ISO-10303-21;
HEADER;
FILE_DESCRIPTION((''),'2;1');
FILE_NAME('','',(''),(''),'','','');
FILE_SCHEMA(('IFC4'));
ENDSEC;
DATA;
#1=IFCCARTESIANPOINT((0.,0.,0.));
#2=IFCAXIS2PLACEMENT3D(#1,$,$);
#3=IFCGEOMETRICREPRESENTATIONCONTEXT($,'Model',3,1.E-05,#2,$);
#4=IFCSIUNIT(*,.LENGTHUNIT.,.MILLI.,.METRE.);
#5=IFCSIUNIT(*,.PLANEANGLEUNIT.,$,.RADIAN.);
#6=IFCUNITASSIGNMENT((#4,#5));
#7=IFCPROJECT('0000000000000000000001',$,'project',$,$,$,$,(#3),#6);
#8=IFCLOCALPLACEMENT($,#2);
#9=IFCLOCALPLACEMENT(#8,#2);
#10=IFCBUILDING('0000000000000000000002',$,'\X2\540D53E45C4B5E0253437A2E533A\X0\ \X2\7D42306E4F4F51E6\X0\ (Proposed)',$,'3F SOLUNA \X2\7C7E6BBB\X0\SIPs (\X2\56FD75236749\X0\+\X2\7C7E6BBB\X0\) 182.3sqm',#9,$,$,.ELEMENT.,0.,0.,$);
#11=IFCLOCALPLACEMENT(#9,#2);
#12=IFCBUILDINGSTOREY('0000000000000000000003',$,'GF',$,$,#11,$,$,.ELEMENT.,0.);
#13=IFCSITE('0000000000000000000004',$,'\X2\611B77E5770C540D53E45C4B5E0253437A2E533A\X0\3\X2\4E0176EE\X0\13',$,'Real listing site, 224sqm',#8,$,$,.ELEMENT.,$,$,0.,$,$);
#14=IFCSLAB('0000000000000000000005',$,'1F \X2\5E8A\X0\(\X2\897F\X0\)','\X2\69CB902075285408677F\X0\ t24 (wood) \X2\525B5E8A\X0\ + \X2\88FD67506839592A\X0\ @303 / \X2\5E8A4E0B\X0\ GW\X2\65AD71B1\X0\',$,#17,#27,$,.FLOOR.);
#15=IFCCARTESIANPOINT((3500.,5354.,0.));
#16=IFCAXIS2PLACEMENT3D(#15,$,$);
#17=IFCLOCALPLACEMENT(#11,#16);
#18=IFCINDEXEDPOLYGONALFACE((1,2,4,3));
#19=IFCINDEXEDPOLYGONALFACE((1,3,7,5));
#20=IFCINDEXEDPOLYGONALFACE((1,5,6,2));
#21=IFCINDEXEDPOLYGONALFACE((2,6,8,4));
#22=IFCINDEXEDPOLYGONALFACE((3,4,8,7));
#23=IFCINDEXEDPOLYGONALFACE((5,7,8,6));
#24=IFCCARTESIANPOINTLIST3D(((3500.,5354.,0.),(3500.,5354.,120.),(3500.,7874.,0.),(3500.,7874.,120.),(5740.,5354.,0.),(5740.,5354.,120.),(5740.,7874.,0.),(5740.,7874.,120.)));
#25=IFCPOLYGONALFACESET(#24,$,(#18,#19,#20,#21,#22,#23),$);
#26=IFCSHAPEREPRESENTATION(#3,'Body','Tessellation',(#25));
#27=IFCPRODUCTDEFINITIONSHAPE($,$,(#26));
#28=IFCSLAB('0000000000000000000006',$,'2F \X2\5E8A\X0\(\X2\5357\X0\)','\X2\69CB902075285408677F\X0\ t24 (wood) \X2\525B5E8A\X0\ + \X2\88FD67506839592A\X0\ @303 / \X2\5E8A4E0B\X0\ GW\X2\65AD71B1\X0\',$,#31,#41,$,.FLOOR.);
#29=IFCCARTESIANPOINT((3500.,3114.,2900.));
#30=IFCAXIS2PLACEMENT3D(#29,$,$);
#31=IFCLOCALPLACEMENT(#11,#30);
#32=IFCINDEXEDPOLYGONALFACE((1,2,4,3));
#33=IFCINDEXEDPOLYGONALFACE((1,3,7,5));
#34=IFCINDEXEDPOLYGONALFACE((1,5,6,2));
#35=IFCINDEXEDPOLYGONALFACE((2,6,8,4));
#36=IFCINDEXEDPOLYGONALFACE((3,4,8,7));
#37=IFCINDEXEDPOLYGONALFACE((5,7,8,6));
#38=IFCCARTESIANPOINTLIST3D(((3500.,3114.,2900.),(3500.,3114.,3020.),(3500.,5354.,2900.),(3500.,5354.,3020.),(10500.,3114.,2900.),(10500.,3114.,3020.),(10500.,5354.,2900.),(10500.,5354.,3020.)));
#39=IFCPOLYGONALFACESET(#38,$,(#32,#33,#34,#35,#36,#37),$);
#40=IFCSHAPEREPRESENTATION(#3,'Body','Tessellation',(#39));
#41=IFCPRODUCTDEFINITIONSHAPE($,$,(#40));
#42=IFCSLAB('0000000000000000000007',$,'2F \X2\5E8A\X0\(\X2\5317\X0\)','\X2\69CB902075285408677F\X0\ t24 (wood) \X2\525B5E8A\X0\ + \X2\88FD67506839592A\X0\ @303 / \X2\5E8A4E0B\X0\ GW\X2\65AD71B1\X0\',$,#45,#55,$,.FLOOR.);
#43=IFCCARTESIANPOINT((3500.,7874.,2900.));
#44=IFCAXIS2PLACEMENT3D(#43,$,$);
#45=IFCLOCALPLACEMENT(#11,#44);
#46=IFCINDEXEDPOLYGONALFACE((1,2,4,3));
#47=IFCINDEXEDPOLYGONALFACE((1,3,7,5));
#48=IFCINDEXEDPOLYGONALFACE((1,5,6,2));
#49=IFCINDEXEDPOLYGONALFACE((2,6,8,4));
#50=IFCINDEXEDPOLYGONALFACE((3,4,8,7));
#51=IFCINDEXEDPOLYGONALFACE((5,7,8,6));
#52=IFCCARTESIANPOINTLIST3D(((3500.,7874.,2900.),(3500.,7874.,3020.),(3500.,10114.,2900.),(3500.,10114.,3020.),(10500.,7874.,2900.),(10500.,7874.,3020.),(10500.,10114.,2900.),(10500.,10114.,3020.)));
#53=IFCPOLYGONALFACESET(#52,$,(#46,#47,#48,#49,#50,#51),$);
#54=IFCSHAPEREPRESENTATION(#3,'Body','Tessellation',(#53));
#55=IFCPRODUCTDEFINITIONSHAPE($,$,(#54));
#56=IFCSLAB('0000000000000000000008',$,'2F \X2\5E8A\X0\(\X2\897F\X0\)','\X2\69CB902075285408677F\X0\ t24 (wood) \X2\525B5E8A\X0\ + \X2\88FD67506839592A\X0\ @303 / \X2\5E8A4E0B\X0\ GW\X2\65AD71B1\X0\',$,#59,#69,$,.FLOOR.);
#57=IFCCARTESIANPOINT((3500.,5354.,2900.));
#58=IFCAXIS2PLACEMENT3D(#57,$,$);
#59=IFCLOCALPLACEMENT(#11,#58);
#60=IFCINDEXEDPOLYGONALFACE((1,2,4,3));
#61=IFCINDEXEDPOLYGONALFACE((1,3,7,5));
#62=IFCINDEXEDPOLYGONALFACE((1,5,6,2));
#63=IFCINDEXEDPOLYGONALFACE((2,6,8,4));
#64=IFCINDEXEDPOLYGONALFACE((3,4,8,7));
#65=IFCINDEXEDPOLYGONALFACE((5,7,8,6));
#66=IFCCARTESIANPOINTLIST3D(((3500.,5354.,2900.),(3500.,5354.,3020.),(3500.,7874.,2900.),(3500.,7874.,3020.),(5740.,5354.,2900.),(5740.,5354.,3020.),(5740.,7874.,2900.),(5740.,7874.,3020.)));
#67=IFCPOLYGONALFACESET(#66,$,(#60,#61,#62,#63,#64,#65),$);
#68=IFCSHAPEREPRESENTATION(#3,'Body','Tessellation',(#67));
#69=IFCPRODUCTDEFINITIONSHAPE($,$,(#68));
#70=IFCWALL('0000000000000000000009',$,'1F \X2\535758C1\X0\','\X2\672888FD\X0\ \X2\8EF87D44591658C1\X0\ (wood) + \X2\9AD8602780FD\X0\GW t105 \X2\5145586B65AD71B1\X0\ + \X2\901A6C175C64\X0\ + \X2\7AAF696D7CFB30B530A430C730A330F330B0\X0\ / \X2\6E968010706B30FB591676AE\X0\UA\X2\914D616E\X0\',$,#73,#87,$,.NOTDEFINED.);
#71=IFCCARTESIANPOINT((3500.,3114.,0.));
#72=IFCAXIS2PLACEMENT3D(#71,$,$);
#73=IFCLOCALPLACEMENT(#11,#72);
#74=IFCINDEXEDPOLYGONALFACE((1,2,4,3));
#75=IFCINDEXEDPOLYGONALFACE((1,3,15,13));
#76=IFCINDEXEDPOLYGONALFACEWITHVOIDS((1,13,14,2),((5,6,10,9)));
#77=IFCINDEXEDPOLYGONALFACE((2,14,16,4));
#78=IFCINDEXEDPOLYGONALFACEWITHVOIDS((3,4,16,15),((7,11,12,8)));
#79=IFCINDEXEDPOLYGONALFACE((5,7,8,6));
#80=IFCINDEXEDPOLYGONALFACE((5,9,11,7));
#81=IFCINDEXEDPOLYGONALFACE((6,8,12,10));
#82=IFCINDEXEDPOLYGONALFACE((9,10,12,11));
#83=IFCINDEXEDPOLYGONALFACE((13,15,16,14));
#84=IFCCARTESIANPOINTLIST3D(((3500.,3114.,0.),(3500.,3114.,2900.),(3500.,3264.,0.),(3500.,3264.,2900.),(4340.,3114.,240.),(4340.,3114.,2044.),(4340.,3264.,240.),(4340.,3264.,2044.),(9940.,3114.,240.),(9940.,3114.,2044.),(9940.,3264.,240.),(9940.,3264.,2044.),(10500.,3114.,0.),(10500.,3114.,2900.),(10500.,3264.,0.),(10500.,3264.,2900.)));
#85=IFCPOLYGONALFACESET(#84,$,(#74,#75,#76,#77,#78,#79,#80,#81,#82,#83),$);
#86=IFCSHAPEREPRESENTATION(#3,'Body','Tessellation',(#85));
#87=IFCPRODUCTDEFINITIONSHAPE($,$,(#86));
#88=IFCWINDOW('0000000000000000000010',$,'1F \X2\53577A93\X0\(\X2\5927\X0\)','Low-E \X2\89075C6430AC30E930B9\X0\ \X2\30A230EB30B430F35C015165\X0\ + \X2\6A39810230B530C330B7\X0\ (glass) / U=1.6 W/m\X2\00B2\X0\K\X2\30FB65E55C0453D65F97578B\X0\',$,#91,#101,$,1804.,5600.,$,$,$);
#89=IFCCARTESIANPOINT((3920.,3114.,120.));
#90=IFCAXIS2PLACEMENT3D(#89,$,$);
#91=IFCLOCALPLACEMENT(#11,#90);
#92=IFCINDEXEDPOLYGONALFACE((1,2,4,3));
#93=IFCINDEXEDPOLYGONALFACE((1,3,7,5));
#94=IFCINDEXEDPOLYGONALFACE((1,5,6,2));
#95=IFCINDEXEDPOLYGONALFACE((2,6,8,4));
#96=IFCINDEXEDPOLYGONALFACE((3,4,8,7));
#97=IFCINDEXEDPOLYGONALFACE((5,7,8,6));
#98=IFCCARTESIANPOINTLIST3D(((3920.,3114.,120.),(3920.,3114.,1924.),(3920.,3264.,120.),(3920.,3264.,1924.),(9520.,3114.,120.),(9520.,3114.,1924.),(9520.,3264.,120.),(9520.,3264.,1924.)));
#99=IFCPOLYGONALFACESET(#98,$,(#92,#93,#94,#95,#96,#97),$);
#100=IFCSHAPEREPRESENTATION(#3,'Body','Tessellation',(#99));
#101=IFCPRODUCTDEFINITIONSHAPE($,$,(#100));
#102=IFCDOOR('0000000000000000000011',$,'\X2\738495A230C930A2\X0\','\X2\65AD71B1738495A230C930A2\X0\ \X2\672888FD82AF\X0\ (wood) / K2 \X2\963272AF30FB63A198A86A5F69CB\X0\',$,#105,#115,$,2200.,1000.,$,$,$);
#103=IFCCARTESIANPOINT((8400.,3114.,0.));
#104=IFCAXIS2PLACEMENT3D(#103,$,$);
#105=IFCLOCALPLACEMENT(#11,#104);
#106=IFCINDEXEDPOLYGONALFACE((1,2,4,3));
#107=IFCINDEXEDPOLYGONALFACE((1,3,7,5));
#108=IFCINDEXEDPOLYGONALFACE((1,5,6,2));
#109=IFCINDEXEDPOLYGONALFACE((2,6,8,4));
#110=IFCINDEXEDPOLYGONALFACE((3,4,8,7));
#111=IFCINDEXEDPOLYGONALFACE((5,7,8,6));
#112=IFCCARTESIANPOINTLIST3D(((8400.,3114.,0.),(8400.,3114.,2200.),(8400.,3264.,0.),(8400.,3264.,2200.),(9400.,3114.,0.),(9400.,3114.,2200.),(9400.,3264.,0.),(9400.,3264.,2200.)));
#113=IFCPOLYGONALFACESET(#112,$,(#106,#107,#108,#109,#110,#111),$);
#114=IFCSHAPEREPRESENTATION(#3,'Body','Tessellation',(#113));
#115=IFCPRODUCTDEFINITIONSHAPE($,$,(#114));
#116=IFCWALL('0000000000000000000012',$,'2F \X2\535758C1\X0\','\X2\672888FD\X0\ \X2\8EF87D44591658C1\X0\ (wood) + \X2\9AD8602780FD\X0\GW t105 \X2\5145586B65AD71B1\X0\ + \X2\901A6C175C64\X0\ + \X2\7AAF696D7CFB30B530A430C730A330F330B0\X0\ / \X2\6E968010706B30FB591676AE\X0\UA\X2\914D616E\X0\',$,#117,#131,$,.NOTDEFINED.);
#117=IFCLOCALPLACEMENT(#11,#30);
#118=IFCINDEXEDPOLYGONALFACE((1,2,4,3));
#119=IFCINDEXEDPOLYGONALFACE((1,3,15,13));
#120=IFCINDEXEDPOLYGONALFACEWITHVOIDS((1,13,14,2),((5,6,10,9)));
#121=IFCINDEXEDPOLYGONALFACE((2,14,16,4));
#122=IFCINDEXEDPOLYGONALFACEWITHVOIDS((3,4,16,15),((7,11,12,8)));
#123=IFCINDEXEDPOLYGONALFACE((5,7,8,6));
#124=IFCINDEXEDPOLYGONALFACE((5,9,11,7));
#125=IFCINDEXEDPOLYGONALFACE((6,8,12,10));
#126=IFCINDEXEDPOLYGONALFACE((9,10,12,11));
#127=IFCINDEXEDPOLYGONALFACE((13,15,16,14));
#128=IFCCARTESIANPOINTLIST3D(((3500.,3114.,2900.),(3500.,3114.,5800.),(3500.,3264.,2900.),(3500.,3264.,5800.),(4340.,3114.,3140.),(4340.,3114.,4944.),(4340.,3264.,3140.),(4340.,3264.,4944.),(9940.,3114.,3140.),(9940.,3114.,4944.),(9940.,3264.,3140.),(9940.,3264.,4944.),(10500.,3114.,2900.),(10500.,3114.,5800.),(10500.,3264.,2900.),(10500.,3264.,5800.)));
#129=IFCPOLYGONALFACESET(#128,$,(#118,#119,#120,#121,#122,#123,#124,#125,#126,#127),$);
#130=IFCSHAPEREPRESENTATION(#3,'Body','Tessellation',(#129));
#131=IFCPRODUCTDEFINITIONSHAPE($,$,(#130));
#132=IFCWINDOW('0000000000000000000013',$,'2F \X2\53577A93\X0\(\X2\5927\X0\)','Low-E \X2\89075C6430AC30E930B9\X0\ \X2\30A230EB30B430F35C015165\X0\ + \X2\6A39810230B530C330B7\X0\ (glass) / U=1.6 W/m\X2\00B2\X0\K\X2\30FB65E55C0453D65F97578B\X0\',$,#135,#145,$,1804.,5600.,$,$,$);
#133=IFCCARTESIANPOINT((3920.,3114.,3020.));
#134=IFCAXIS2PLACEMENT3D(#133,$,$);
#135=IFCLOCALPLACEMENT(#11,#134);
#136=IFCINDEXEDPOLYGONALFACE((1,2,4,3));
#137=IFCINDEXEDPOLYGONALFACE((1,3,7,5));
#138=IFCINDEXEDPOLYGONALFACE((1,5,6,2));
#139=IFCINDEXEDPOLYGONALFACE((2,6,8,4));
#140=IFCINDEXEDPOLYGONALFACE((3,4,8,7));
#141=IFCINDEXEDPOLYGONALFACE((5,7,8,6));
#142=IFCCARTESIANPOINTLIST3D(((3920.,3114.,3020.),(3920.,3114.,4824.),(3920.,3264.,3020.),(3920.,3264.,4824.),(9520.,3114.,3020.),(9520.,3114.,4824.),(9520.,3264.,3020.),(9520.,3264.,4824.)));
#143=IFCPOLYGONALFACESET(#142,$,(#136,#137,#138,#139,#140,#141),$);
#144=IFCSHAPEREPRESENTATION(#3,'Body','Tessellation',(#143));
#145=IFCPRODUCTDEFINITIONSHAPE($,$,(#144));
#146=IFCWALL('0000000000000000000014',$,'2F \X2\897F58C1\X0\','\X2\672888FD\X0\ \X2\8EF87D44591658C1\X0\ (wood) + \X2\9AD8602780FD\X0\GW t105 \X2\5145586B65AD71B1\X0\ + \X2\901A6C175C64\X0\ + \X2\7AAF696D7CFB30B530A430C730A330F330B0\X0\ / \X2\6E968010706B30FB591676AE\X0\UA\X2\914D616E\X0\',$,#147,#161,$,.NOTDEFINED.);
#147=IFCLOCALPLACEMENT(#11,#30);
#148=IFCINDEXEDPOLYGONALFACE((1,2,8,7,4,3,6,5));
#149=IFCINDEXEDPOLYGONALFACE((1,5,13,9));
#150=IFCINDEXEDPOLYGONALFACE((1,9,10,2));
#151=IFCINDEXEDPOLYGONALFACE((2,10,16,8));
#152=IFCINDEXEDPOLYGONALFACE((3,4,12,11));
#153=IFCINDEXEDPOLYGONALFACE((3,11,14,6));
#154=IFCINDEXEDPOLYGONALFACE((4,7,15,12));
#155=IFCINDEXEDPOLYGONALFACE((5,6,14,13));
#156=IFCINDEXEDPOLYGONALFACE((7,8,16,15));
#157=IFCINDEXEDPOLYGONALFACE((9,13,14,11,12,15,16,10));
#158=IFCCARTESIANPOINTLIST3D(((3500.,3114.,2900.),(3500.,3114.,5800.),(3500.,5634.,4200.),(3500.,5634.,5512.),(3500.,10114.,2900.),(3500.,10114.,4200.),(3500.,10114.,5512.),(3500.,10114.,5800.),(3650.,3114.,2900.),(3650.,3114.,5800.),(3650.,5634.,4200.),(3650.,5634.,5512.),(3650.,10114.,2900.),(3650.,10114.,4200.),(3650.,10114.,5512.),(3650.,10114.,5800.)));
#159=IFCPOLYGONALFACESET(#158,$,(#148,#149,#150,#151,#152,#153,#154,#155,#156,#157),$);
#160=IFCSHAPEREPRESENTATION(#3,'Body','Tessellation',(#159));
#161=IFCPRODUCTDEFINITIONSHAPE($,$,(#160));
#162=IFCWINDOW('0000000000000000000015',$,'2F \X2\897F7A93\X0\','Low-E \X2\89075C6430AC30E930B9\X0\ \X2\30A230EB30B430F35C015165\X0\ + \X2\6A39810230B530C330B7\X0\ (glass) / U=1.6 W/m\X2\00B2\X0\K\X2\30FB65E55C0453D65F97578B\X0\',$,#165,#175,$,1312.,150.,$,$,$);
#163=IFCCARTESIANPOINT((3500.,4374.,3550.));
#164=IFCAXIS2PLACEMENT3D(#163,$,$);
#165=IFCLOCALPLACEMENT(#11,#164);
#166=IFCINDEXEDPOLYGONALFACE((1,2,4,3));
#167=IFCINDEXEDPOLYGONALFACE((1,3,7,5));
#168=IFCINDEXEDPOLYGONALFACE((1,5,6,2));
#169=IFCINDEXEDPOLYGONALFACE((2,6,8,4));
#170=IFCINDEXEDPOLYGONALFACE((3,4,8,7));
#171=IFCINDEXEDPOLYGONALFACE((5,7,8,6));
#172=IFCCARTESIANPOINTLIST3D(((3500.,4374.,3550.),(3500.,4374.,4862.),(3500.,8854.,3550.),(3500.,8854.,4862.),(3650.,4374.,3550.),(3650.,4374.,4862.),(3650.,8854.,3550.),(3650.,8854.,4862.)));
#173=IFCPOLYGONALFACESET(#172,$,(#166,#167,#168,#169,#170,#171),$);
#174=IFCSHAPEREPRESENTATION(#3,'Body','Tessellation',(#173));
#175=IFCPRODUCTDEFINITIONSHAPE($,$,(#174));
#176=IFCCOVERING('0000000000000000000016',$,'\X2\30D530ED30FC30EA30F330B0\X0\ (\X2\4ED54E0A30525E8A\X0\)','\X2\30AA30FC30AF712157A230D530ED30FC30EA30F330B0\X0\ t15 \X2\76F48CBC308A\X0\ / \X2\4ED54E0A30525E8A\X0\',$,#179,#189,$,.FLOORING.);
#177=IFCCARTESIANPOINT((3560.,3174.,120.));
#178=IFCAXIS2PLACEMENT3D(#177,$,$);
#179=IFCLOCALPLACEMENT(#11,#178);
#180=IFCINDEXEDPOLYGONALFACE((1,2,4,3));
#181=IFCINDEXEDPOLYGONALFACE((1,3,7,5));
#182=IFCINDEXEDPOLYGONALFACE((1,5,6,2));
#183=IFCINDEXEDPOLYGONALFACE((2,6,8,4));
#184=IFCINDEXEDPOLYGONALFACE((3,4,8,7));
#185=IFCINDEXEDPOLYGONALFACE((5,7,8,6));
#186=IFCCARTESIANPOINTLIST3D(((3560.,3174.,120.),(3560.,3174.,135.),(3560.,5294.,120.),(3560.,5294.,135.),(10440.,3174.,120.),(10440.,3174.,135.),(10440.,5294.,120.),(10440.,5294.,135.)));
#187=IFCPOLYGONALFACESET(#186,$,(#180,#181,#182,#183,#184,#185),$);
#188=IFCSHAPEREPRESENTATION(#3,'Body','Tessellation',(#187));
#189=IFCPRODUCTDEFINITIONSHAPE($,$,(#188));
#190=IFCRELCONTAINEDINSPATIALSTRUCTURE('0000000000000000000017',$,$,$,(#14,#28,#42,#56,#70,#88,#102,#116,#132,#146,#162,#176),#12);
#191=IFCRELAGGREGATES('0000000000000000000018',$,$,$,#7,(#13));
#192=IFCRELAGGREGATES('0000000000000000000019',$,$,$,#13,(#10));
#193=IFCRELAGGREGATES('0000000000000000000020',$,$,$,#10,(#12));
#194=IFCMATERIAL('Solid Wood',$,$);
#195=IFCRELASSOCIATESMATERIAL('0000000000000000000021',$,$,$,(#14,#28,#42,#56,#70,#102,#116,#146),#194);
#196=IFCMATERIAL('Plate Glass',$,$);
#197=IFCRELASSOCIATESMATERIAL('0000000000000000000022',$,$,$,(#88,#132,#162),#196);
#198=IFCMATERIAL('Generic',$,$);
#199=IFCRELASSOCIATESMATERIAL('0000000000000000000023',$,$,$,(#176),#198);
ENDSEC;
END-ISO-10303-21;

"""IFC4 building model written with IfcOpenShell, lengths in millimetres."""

from ifc_helpers import new_model, si_unit, frame, frame_2d, origin, place, context, project, spatial, rectangle, extrude, material, element, fill, save


model = new_model("IFC4")

# Units and contexts
model_context = context("Model", 3, precision=1e-05, world=origin())
ifc_project = project(units=[si_unit("LENGTHUNIT", "METRE", prefix="MILLI"), si_unit("PLANEANGLEUNIT", "RADIAN")], contexts=[model_context])

# Site, building, storey
site_placement = place(None, origin())
site = spatial("IfcSite", under=ifc_project, at=site_placement, Name="愛知県名古屋市千種区3丁目13", ObjectType="Real listing site, 224sqm", CompositionType="ELEMENT", RefElevation=0.0)
building_placement = place(site_placement, origin())
building = spatial("IfcBuilding", under=site, at=building_placement, Name="名古屋市千種区 終の住処 (Proposed)", ObjectType="3F SOLUNA 籾殻SIPs (国産杉+籾殻) 182.3sqm", CompositionType="ELEMENT", ElevationOfRefHeight=0.0, ElevationOfTerrain=0.0)
storey_placement = place(building_placement, origin())
storey = spatial("IfcBuildingStorey", under=building, at=storey_placement, Name="GF", CompositionType="ELEMENT", Elevation=0.0)

# Slabs
ifc_material_1 = material(Name="Solid Wood")
slab_1_placement = place(storey_placement, frame((3500.0, 5354.0, 0.0)))
element("IfcSlab", 1, at=slab_1_placement, inside=storey, material=ifc_material_1, Name="1F 床(西)", Description="構造用合板 t24 (wood) 剛床 + 製材根太 @303 / 床下 GW断熱", PredefinedType="FLOOR", context=model_context, shape_type="SweptSolid", body=[
    extrude(rectangle(XDim=2240.0, YDim=2520.0, at=frame_2d((1120.0, 1260.0))), frame((3500.0, 5354.0, 0.0)), (0.0, 0.0, 1.0), 120.0),
])
slab_2_placement = place(storey_placement, frame((3500.0, 3114.0, 2900.0)))
element("IfcSlab", 2, at=slab_2_placement, inside=storey, material=ifc_material_1, Name="2F 床(南)", Description="構造用合板 t24 (wood) 剛床 + 製材根太 @303 / 床下 GW断熱", PredefinedType="FLOOR", context=model_context, shape_type="SweptSolid", body=[
    extrude(rectangle(XDim=7000.0, YDim=2240.0, at=frame_2d((3500.0, 1120.0))), frame((3500.0, 3114.0, 2900.0)), (0.0, 0.0, 1.0), 120.0),
])
slab_3_placement = place(storey_placement, frame((3500.0, 7874.0, 2900.0)))
element("IfcSlab", 3, at=slab_3_placement, inside=storey, material=ifc_material_1, Name="2F 床(北)", Description="構造用合板 t24 (wood) 剛床 + 製材根太 @303 / 床下 GW断熱", PredefinedType="FLOOR", context=model_context, shape_type="SweptSolid", body=[
    extrude(rectangle(XDim=7000.0, YDim=2240.0, at=frame_2d((3500.0, 1120.0))), frame((3500.0, 7874.0, 2900.0)), (0.0, 0.0, 1.0), 120.0),
])
slab_4_placement = place(storey_placement, frame((3500.0, 5354.0, 2900.0)))
element("IfcSlab", 4, at=slab_4_placement, inside=storey, material=ifc_material_1, Name="2F 床(西)", Description="構造用合板 t24 (wood) 剛床 + 製材根太 @303 / 床下 GW断熱", PredefinedType="FLOOR", context=model_context, shape_type="SweptSolid", body=[
    extrude(rectangle(XDim=2240.0, YDim=2520.0, at=frame_2d((1120.0, 1260.0))), frame((3500.0, 5354.0, 2900.0)), (0.0, 0.0, 1.0), 120.0),
])

# Wall, openings, window, door
wall_1_placement = place(storey_placement, frame((3500.0, 3114.0, 0.0)))
wall_1 = element("IfcWall", 5, at=wall_1_placement, inside=storey, material=ifc_material_1, Name="1F 南壁", Description="木製 軸組外壁 (wood) + 高性能GW t105 充填断熱 + 通気層 + 窯業系サイディング / 準耐火・外皮UA配慮", PredefinedType="NOTDEFINED", context=model_context, shape_type="SweptSolid", body=[
    extrude(rectangle(XDim=7000.0, YDim=150.0, at=frame_2d((3500.0, 75.0))), frame((3500.0, 3114.0, 0.0)), (0.0, 0.0, 1.0), 2900.0),
])
opening_1_placement = place(storey_placement, frame((3920.0, 3114.0, 120.0)))
opening_1 = element("IfcOpeningElement", 6, at=opening_1_placement, cuts=wall_1, PredefinedType="NOTDEFINED", context=model_context, shape_type="SweptSolid", body=[
    extrude(rectangle(XDim=5600.0, YDim=150.0, at=frame_2d((2800.0, 75.0))), frame((3920.0, 3114.0, 120.0)), (0.0, 0.0, 1.0), 1804.0),
])
opening_2_placement = place(storey_placement, frame((8400.0, 3114.0, 0.0)))
opening_2 = element("IfcOpeningElement", 7, at=opening_2_placement, cuts=wall_1, PredefinedType="NOTDEFINED", context=model_context, shape_type="SweptSolid", body=[
    extrude(rectangle(XDim=1000.0, YDim=150.0, at=frame_2d((500.0, 75.0))), frame((8400.0, 3114.0, 0.0)), (0.0, 0.0, 1.0), 2200.0),
])
ifc_material_2 = material(Name="Plate Glass")
window_1_placement = place(storey_placement, frame((3920.0, 3114.0, 120.0)))
window_1 = element("IfcWindow", 8, at=window_1_placement, inside=storey, material=ifc_material_2, Name="1F 南窓(大)", Description="Low-E 複層ガラス アルゴン封入 + 樹脂サッシ (glass) / U=1.6 W/m²K・日射取得型", OverallHeight=1804.0, OverallWidth=5600.0, context=model_context, shape_type="SweptSolid", body=[
    extrude(rectangle(XDim=5600.0, YDim=150.0, at=frame_2d((2800.0, 75.0))), frame((3920.0, 3114.0, 120.0)), (0.0, 0.0, 1.0), 1804.0),
])
fill(opening_1, window_1)
door_placement = place(storey_placement, frame((8400.0, 3114.0, 0.0)))
door = element("IfcDoor", 9, at=door_placement, inside=storey, material=ifc_material_1, Name="玄関ドア", Description="断熱玄関ドア 木製芯 (wood) / K2 防犯・採風機構", OverallHeight=2200.0, OverallWidth=1000.0, context=model_context, shape_type="SweptSolid", body=[
    extrude(rectangle(XDim=1000.0, YDim=150.0, at=frame_2d((500.0, 75.0))), frame((8400.0, 3114.0, 0.0)), (0.0, 0.0, 1.0), 2200.0),
])
fill(opening_2, door)

# Wall, opening, window
wall_2_placement = place(storey_placement, frame((3500.0, 3114.0, 2900.0)))
wall_2 = element("IfcWall", 10, at=wall_2_placement, inside=storey, material=ifc_material_1, Name="2F 南壁", Description="木製 軸組外壁 (wood) + 高性能GW t105 充填断熱 + 通気層 + 窯業系サイディング / 準耐火・外皮UA配慮", PredefinedType="NOTDEFINED", context=model_context, shape_type="SweptSolid", body=[
    extrude(rectangle(XDim=7000.0, YDim=150.0, at=frame_2d((3500.0, 75.0))), frame((3500.0, 3114.0, 2900.0)), (0.0, 0.0, 1.0), 2900.0),
])
opening_3_placement = place(storey_placement, frame((3920.0, 3114.0, 3020.0)))
opening_3 = element("IfcOpeningElement", 11, at=opening_3_placement, cuts=wall_2, PredefinedType="NOTDEFINED", context=model_context, shape_type="SweptSolid", body=[
    extrude(rectangle(XDim=5600.0, YDim=150.0, at=frame_2d((2800.0, 75.0))), frame((3920.0, 3114.0, 3020.0)), (0.0, 0.0, 1.0), 1804.0),
])
window_2_placement = place(storey_placement, frame((3920.0, 3114.0, 3020.0)))
window_2 = element("IfcWindow", 12, at=window_2_placement, inside=storey, material=ifc_material_2, Name="2F 南窓(大)", Description="Low-E 複層ガラス アルゴン封入 + 樹脂サッシ (glass) / U=1.6 W/m²K・日射取得型", OverallHeight=1804.0, OverallWidth=5600.0, context=model_context, shape_type="SweptSolid", body=[
    extrude(rectangle(XDim=5600.0, YDim=150.0, at=frame_2d((2800.0, 75.0))), frame((3920.0, 3114.0, 3020.0)), (0.0, 0.0, 1.0), 1804.0),
])
fill(opening_3, window_2)

# Wall, opening, window
wall_3_placement = place(storey_placement, frame((3500.0, 3114.0, 2900.0)))
wall_3 = element("IfcWall", 13, at=wall_3_placement, inside=storey, material=ifc_material_1, Name="2F 西壁", Description="木製 軸組外壁 (wood) + 高性能GW t105 充填断熱 + 通気層 + 窯業系サイディング / 準耐火・外皮UA配慮", PredefinedType="NOTDEFINED", context=model_context, shape_type="SweptSolid", body=[
    extrude(rectangle(XDim=150.0, YDim=7000.0, at=frame_2d((75.0, 3500.0))), frame((3500.0, 3114.0, 2900.0)), (0.0, 0.0, 1.0), 2900.0),
])
opening_4_placement = place(storey_placement, frame((3500.0, 4374.0, 3550.0)))
opening_4 = element("IfcOpeningElement", 14, at=opening_4_placement, cuts=wall_3, PredefinedType="NOTDEFINED", context=model_context, shape_type="SweptSolid", body=[
    extrude(rectangle(XDim=150.0, YDim=4480.0, at=frame_2d((75.0, 2240.0))), frame((3500.0, 4374.0, 3550.0)), (0.0, 0.0, 1.0), 1312.0),
])
window_3_placement = place(storey_placement, frame((3500.0, 4374.0, 3550.0)))
window_3 = element("IfcWindow", 15, at=window_3_placement, inside=storey, material=ifc_material_2, Name="2F 西窓", Description="Low-E 複層ガラス アルゴン封入 + 樹脂サッシ (glass) / U=1.6 W/m²K・日射取得型", OverallHeight=1312.0, OverallWidth=150.0, context=model_context, shape_type="SweptSolid", body=[
    extrude(rectangle(XDim=150.0, YDim=4480.0, at=frame_2d((75.0, 2240.0))), frame((3500.0, 4374.0, 3550.0)), (0.0, 0.0, 1.0), 1312.0),
])
fill(opening_4, window_3)

# Covering
ifc_material_3 = material(Name="Generic")
covering_1_placement = place(storey_placement, frame((3560.0, 3174.0, 120.0)))
element("IfcCovering", 16, at=covering_1_placement, inside=storey, material=ifc_material_3, Name="フローリング (仕上げ床)", Description="オーク無垢フローリング t15 直貼り / 仕上げ床", PredefinedType="FLOORING", context=model_context, shape_type="SweptSolid", body=[
    extrude(rectangle(XDim=6880.0, YDim=2120.0, at=frame_2d((3440.0, 1060.0))), frame((3560.0, 3174.0, 120.0)), (0.0, 0.0, 1.0), 15.0),
])

save(model, "model.ifc")
